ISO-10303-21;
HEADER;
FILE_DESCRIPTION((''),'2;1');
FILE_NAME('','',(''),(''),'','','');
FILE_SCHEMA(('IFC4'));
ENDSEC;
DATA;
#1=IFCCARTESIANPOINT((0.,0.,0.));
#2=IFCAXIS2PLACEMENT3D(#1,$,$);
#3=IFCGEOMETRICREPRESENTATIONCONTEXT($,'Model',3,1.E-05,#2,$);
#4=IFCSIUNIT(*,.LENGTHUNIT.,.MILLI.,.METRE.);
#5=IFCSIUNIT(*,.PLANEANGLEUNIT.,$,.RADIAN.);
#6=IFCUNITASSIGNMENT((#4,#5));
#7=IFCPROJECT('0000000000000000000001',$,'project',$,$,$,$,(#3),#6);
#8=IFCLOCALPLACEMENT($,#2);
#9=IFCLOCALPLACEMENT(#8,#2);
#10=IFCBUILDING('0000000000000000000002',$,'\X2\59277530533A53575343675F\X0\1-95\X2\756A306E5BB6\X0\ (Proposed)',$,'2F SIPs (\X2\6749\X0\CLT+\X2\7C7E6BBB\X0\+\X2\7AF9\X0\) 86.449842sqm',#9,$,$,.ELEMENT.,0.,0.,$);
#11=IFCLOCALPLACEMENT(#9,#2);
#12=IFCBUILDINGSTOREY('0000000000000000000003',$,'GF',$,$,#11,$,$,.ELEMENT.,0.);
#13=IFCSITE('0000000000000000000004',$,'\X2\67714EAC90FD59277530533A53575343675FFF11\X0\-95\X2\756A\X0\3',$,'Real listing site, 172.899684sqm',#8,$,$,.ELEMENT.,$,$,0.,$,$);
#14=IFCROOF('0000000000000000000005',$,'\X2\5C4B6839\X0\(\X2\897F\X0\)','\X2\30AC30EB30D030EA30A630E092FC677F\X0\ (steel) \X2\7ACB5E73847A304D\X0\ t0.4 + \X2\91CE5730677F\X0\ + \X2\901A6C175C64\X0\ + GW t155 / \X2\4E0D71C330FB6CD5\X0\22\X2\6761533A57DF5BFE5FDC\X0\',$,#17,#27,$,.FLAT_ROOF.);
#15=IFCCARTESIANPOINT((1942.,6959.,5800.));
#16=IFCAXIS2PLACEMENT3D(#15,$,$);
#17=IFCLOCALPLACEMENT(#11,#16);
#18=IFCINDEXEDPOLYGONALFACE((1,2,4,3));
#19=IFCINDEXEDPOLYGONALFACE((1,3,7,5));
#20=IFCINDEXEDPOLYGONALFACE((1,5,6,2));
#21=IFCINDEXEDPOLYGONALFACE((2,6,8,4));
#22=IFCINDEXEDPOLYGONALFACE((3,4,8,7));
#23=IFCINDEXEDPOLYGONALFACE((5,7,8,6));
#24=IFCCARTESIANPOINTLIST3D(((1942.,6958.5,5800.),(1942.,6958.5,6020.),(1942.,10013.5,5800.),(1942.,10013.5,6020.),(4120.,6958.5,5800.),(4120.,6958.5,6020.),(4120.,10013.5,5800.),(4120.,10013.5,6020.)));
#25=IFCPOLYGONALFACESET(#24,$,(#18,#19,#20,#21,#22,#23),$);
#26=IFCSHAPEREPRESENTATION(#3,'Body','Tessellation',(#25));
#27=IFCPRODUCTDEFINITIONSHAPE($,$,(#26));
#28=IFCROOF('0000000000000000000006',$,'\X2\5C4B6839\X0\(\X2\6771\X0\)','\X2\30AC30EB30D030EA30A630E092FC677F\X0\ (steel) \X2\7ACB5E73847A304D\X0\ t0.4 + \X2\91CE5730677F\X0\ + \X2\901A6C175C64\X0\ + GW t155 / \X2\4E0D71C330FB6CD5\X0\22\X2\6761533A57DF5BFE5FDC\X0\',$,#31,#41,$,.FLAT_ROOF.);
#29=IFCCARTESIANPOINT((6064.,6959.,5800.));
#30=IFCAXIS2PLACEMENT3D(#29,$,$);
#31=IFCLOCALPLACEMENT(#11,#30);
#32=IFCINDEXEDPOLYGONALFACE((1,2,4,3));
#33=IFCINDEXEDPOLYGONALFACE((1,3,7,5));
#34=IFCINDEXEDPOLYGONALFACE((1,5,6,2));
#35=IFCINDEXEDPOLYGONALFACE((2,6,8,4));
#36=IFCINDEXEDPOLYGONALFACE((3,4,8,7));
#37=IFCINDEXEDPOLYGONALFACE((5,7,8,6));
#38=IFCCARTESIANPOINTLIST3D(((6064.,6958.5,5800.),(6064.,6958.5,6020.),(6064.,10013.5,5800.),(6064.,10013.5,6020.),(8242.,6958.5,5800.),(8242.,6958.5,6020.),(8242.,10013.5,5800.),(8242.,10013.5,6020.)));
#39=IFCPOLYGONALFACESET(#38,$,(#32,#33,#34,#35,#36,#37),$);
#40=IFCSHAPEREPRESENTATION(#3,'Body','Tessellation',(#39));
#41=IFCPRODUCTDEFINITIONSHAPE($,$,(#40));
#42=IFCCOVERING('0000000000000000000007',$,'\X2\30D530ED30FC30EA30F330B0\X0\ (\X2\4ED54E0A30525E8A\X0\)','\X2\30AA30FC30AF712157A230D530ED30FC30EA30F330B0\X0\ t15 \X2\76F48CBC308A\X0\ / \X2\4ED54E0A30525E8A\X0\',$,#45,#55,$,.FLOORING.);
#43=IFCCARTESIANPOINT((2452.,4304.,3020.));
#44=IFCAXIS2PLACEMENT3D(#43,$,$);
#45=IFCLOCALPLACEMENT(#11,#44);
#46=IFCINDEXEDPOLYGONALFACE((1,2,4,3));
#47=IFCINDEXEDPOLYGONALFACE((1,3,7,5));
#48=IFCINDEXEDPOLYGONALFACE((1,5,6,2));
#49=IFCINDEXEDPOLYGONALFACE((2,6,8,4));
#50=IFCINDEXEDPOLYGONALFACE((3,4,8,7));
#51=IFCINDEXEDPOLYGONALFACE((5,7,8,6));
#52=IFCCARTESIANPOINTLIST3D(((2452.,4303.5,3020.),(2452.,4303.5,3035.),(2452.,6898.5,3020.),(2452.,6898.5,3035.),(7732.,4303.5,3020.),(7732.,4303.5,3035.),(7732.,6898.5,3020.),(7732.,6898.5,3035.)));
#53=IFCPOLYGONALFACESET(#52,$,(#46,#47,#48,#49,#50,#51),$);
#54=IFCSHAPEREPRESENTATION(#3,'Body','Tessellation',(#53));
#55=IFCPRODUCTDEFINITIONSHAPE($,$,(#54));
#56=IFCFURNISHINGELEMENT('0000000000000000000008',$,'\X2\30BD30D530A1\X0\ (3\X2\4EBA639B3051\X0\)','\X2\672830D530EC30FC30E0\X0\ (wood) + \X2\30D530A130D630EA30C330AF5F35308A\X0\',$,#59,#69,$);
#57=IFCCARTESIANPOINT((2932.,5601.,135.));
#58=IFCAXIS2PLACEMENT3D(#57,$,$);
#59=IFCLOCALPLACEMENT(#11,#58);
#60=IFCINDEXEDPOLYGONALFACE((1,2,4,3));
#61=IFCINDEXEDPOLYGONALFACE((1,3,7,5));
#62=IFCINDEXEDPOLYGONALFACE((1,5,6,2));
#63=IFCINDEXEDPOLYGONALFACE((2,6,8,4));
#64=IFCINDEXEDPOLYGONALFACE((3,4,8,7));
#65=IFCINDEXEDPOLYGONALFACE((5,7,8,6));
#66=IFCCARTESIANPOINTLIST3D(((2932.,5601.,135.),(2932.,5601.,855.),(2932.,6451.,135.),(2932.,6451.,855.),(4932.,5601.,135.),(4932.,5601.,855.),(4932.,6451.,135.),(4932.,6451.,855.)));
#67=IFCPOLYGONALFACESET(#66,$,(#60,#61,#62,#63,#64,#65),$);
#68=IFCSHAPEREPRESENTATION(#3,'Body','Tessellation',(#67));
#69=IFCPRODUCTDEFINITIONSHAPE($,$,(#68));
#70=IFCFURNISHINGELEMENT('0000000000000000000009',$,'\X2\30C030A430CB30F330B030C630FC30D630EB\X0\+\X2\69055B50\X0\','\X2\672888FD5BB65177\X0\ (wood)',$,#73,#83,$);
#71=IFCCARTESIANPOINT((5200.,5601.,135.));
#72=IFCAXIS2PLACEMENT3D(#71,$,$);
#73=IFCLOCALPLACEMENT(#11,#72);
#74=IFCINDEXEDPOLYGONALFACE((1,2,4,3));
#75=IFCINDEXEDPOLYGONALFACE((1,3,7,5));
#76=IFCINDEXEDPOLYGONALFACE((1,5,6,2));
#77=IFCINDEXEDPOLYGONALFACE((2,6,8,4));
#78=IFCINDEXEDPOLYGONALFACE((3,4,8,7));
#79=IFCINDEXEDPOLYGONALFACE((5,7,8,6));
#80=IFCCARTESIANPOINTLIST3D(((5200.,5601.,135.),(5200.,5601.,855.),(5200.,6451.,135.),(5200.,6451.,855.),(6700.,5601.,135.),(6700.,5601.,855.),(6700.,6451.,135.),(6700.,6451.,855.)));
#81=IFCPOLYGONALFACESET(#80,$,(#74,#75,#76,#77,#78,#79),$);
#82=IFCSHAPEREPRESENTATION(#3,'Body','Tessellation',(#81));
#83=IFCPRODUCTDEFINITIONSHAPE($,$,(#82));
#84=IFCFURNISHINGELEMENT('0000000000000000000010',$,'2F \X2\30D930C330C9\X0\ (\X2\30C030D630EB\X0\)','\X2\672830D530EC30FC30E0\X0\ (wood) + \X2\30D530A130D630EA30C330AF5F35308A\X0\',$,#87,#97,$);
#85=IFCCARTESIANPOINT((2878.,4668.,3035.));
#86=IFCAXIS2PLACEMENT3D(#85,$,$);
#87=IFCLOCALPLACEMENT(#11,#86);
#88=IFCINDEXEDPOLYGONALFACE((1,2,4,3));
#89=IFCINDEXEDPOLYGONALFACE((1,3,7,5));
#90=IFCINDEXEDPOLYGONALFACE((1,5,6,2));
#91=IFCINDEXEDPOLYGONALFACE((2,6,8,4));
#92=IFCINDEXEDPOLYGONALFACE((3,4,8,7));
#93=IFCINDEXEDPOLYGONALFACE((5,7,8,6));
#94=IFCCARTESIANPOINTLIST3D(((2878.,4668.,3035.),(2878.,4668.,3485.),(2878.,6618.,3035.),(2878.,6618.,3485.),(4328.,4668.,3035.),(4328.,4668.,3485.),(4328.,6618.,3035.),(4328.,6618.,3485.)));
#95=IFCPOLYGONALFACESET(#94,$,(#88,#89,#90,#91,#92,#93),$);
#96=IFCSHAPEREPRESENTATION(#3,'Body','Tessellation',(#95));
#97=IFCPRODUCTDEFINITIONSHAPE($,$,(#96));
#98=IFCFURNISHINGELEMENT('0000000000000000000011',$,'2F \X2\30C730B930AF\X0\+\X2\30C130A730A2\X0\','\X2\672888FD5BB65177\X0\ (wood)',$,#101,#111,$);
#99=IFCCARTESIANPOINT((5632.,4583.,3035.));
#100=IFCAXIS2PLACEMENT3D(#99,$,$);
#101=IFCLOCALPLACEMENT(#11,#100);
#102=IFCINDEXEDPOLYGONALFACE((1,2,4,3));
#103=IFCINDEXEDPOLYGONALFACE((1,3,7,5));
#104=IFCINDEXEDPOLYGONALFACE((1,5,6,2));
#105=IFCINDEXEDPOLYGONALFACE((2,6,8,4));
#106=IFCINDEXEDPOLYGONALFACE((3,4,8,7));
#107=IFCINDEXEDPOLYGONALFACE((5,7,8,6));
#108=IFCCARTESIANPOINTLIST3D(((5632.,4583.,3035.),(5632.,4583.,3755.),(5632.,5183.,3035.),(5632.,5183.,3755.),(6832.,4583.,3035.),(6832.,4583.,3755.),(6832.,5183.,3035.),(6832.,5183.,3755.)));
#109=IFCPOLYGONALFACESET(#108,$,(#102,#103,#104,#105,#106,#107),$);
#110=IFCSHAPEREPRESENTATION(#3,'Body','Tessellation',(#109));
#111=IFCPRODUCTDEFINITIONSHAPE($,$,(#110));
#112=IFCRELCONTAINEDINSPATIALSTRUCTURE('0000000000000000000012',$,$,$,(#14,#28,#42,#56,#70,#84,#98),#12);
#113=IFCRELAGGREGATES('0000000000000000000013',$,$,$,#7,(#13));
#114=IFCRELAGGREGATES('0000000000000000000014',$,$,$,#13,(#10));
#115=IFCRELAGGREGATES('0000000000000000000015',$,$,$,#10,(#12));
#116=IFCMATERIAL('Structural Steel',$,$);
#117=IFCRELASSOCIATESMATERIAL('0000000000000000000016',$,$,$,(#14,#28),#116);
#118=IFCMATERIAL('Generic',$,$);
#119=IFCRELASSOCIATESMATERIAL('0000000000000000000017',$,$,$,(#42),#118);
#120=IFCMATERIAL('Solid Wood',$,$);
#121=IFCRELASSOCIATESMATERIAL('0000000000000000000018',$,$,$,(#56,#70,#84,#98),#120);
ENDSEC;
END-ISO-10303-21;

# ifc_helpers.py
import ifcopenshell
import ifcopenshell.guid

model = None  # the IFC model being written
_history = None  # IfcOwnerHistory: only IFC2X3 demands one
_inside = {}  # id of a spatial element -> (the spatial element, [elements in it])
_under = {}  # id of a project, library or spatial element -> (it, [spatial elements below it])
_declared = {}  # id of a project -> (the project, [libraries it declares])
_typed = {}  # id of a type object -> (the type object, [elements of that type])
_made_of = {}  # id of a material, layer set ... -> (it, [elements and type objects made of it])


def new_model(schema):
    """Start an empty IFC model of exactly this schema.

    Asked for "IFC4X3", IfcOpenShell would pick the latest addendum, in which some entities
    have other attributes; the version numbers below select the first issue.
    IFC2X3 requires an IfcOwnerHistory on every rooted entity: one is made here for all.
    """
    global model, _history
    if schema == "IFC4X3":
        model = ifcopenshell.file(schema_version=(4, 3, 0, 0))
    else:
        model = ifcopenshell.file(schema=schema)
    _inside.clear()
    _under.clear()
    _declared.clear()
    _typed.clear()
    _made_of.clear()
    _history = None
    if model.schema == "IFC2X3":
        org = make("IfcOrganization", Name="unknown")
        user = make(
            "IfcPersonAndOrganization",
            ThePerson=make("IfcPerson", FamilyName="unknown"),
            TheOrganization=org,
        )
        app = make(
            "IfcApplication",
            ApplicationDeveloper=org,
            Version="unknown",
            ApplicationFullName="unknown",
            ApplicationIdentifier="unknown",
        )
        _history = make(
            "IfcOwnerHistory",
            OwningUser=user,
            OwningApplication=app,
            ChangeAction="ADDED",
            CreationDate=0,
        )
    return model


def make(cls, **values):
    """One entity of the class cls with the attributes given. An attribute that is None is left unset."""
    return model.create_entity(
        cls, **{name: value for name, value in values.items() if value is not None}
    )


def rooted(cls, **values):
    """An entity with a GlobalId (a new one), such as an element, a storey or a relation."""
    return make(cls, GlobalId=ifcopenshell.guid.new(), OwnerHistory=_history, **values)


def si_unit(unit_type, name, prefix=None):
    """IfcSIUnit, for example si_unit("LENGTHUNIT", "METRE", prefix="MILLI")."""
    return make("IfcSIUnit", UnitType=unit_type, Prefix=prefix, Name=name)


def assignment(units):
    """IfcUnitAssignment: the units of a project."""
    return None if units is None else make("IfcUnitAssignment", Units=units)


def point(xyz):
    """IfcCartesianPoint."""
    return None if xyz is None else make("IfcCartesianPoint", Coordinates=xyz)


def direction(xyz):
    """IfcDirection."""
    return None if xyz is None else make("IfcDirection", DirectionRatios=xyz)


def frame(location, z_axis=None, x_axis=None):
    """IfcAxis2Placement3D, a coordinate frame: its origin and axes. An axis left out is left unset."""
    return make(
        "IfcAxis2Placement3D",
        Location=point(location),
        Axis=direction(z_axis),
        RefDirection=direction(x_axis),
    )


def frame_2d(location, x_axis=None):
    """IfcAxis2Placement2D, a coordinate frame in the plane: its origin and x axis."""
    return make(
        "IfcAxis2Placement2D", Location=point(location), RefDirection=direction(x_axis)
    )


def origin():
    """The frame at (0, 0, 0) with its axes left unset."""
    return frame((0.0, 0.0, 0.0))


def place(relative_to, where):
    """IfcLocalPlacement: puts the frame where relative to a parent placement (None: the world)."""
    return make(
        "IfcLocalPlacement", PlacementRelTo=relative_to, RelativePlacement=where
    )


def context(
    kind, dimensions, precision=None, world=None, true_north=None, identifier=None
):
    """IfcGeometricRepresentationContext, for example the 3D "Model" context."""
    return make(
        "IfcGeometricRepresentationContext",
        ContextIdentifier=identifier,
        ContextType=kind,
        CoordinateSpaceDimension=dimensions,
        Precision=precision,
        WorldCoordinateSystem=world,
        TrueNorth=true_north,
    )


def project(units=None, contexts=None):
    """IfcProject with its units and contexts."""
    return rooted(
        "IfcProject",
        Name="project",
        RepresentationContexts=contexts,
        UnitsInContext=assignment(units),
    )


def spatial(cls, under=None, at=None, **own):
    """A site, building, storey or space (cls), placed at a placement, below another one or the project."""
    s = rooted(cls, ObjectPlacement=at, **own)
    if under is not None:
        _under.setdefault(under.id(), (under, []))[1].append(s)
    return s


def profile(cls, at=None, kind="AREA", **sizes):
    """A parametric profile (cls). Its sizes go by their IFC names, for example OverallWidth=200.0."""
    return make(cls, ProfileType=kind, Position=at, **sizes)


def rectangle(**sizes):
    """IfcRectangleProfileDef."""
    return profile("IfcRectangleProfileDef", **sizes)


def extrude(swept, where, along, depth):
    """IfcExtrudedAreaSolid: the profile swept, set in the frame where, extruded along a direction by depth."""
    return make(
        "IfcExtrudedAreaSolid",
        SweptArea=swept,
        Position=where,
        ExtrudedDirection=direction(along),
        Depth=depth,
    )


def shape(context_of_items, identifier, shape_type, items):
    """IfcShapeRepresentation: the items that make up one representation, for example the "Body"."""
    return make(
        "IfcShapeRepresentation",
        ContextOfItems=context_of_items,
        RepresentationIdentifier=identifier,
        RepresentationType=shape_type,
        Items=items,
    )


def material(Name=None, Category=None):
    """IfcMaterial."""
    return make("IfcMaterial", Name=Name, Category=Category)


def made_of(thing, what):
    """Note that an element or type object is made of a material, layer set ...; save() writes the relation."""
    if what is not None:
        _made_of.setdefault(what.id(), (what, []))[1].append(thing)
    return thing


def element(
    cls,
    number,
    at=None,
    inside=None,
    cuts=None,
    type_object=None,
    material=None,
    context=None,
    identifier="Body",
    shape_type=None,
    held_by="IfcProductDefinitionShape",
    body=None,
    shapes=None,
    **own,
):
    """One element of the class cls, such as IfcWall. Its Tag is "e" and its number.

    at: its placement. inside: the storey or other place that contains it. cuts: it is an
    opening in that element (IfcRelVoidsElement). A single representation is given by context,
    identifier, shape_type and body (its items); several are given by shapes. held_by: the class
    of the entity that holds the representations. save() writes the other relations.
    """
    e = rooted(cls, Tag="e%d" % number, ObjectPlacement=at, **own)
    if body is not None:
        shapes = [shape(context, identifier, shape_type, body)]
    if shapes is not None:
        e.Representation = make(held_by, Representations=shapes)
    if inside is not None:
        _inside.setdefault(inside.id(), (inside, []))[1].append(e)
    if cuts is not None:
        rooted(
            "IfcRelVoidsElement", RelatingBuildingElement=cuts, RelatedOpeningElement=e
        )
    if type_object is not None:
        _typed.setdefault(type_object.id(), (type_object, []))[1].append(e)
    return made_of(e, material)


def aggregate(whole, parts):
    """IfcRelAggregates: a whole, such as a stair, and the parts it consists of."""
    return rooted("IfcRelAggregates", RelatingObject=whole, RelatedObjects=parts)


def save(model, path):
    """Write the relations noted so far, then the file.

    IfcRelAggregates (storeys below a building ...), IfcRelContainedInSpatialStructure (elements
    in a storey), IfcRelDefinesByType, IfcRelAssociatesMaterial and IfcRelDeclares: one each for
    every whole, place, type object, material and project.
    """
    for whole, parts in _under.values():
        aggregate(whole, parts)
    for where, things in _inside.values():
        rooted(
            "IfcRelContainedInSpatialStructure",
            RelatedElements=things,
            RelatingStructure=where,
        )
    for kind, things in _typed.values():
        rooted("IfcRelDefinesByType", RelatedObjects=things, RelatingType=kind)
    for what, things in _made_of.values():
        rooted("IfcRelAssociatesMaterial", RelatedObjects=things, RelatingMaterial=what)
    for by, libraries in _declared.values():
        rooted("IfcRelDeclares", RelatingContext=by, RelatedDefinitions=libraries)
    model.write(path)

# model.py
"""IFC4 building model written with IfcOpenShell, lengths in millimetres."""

from ifc_helpers import new_model, si_unit, frame, frame_2d, origin, place, context, project, spatial, rectangle, extrude, material, element, save


model = new_model("IFC4")

# Units and contexts
model_context = context("Model", 3, precision=1e-05, world=origin())
ifc_project = project(units=[si_unit("LENGTHUNIT", "METRE", prefix="MILLI"), si_unit("PLANEANGLEUNIT", "RADIAN")], contexts=[model_context])

# Site, building, storey
site_placement = place(None, origin())
site = spatial("IfcSite", under=ifc_project, at=site_placement, Name="東京都大田区南千束１-95番3", ObjectType="Real listing site, 172.899684sqm", CompositionType="ELEMENT", RefElevation=0.0)
building_placement = place(site_placement, origin())
building = spatial("IfcBuilding", under=site, at=building_placement, Name="大田区南千束1-95番の家 (Proposed)", ObjectType="2F SIPs (杉CLT+籾殻+竹) 86.449842sqm", CompositionType="ELEMENT", ElevationOfRefHeight=0.0, ElevationOfTerrain=0.0)
storey_placement = place(building_placement, origin())
storey = spatial("IfcBuildingStorey", under=building, at=storey_placement, Name="GF", CompositionType="ELEMENT", Elevation=0.0)

# Shared definitions
ifc_material_1 = material(Name="Solid Wood")

# Roofs
ifc_material_2 = material(Name="Structural Steel")
roof_1_placement = place(storey_placement, frame((1942.0, 6959.0, 5800.0)))
element("IfcRoof", 1, at=roof_1_placement, inside=storey, material=ifc_material_2, Name="屋根(西)", Description="ガルバリウム鋼板 (steel) 立平葺き t0.4 + 野地板 + 通気層 + GW t155 / 不燃・法22条区域対応", PredefinedType="FLAT_ROOF", context=model_context, shape_type="SweptSolid", body=[
    extrude(rectangle(XDim=2178.0, YDim=3055.0, at=frame_2d((1089.0, 1527.0))), frame((1942.0, 6959.0, 5800.0)), (0.0, 0.0, 1.0), 220.0),
])
roof_2_placement = place(storey_placement, frame((6064.0, 6959.0, 5800.0)))
element("IfcRoof", 2, at=roof_2_placement, inside=storey, material=ifc_material_2, Name="屋根(東)", Description="ガルバリウム鋼板 (steel) 立平葺き t0.4 + 野地板 + 通気層 + GW t155 / 不燃・法22条区域対応", PredefinedType="FLAT_ROOF", context=model_context, shape_type="SweptSolid", body=[
    extrude(rectangle(XDim=2178.0, YDim=3055.0, at=frame_2d((1089.0, 1527.0))), frame((6064.0, 6959.0, 5800.0)), (0.0, 0.0, 1.0), 220.0),
])

# Covering
ifc_material_3 = material(Name="Generic")
covering_placement = place(storey_placement, frame((2452.0, 4304.0, 3020.0)))
element("IfcCovering", 3, at=covering_placement, inside=storey, material=ifc_material_3, Name="フローリング (仕上げ床)", Description="オーク無垢フローリング t15 直貼り / 仕上げ床", PredefinedType="FLOORING", context=model_context, shape_type="SweptSolid", body=[
    extrude(rectangle(XDim=5280.0, YDim=2595.0, at=frame_2d((2640.0, 1297.0))), frame((2452.0, 4304.0, 3020.0)), (0.0, 0.0, 1.0), 15.0),
])

# Furnishing elements
furnishing_1_placement = place(storey_placement, frame((2932.0, 5601.0, 135.0)))
element("IfcFurnishingElement", 4, at=furnishing_1_placement, inside=storey, material=ifc_material_1, Name="ソファ (3人掛け)", Description="木フレーム (wood) + ファブリック張り", context=model_context, shape_type="SweptSolid", body=[
    extrude(rectangle(XDim=2000.0, YDim=850.0, at=frame_2d((1000.0, 425.0))), frame((2932.0, 5601.0, 135.0)), (0.0, 0.0, 1.0), 720.0),
])
furnishing_2_placement = place(storey_placement, frame((5200.0, 5601.0, 135.0)))
element("IfcFurnishingElement", 5, at=furnishing_2_placement, inside=storey, material=ifc_material_1, Name="ダイニングテーブル+椅子", Description="木製家具 (wood)", context=model_context, shape_type="SweptSolid", body=[
    extrude(rectangle(XDim=1500.0, YDim=850.0, at=frame_2d((750.0, 425.0))), frame((5200.0, 5601.0, 135.0)), (0.0, 0.0, 1.0), 720.0),
])
furnishing_3_placement = place(storey_placement, frame((2878.0, 4668.0, 3035.0)))
element("IfcFurnishingElement", 6, at=furnishing_3_placement, inside=storey, material=ifc_material_1, Name="2F ベッド (ダブル)", Description="木フレーム (wood) + ファブリック張り", context=model_context, shape_type="SweptSolid", body=[
    extrude(rectangle(XDim=1450.0, YDim=1950.0, at=frame_2d((725.0, 975.0))), frame((2878.0, 4668.0, 3035.0)), (0.0, 0.0, 1.0), 450.0),
])
furnishing_4_placement = place(storey_placement, frame((5632.0, 4583.0, 3035.0)))
element("IfcFurnishingElement", 7, at=furnishing_4_placement, inside=storey, material=ifc_material_1, Name="2F デスク+チェア", Description="木製家具 (wood)", context=model_context, shape_type="SweptSolid", body=[
    extrude(rectangle(XDim=1200.0, YDim=600.0, at=frame_2d((600.0, 300.0))), frame((5632.0, 4583.0, 3035.0)), (0.0, 0.0, 1.0), 720.0),
])

save(model, "model.ifc")
